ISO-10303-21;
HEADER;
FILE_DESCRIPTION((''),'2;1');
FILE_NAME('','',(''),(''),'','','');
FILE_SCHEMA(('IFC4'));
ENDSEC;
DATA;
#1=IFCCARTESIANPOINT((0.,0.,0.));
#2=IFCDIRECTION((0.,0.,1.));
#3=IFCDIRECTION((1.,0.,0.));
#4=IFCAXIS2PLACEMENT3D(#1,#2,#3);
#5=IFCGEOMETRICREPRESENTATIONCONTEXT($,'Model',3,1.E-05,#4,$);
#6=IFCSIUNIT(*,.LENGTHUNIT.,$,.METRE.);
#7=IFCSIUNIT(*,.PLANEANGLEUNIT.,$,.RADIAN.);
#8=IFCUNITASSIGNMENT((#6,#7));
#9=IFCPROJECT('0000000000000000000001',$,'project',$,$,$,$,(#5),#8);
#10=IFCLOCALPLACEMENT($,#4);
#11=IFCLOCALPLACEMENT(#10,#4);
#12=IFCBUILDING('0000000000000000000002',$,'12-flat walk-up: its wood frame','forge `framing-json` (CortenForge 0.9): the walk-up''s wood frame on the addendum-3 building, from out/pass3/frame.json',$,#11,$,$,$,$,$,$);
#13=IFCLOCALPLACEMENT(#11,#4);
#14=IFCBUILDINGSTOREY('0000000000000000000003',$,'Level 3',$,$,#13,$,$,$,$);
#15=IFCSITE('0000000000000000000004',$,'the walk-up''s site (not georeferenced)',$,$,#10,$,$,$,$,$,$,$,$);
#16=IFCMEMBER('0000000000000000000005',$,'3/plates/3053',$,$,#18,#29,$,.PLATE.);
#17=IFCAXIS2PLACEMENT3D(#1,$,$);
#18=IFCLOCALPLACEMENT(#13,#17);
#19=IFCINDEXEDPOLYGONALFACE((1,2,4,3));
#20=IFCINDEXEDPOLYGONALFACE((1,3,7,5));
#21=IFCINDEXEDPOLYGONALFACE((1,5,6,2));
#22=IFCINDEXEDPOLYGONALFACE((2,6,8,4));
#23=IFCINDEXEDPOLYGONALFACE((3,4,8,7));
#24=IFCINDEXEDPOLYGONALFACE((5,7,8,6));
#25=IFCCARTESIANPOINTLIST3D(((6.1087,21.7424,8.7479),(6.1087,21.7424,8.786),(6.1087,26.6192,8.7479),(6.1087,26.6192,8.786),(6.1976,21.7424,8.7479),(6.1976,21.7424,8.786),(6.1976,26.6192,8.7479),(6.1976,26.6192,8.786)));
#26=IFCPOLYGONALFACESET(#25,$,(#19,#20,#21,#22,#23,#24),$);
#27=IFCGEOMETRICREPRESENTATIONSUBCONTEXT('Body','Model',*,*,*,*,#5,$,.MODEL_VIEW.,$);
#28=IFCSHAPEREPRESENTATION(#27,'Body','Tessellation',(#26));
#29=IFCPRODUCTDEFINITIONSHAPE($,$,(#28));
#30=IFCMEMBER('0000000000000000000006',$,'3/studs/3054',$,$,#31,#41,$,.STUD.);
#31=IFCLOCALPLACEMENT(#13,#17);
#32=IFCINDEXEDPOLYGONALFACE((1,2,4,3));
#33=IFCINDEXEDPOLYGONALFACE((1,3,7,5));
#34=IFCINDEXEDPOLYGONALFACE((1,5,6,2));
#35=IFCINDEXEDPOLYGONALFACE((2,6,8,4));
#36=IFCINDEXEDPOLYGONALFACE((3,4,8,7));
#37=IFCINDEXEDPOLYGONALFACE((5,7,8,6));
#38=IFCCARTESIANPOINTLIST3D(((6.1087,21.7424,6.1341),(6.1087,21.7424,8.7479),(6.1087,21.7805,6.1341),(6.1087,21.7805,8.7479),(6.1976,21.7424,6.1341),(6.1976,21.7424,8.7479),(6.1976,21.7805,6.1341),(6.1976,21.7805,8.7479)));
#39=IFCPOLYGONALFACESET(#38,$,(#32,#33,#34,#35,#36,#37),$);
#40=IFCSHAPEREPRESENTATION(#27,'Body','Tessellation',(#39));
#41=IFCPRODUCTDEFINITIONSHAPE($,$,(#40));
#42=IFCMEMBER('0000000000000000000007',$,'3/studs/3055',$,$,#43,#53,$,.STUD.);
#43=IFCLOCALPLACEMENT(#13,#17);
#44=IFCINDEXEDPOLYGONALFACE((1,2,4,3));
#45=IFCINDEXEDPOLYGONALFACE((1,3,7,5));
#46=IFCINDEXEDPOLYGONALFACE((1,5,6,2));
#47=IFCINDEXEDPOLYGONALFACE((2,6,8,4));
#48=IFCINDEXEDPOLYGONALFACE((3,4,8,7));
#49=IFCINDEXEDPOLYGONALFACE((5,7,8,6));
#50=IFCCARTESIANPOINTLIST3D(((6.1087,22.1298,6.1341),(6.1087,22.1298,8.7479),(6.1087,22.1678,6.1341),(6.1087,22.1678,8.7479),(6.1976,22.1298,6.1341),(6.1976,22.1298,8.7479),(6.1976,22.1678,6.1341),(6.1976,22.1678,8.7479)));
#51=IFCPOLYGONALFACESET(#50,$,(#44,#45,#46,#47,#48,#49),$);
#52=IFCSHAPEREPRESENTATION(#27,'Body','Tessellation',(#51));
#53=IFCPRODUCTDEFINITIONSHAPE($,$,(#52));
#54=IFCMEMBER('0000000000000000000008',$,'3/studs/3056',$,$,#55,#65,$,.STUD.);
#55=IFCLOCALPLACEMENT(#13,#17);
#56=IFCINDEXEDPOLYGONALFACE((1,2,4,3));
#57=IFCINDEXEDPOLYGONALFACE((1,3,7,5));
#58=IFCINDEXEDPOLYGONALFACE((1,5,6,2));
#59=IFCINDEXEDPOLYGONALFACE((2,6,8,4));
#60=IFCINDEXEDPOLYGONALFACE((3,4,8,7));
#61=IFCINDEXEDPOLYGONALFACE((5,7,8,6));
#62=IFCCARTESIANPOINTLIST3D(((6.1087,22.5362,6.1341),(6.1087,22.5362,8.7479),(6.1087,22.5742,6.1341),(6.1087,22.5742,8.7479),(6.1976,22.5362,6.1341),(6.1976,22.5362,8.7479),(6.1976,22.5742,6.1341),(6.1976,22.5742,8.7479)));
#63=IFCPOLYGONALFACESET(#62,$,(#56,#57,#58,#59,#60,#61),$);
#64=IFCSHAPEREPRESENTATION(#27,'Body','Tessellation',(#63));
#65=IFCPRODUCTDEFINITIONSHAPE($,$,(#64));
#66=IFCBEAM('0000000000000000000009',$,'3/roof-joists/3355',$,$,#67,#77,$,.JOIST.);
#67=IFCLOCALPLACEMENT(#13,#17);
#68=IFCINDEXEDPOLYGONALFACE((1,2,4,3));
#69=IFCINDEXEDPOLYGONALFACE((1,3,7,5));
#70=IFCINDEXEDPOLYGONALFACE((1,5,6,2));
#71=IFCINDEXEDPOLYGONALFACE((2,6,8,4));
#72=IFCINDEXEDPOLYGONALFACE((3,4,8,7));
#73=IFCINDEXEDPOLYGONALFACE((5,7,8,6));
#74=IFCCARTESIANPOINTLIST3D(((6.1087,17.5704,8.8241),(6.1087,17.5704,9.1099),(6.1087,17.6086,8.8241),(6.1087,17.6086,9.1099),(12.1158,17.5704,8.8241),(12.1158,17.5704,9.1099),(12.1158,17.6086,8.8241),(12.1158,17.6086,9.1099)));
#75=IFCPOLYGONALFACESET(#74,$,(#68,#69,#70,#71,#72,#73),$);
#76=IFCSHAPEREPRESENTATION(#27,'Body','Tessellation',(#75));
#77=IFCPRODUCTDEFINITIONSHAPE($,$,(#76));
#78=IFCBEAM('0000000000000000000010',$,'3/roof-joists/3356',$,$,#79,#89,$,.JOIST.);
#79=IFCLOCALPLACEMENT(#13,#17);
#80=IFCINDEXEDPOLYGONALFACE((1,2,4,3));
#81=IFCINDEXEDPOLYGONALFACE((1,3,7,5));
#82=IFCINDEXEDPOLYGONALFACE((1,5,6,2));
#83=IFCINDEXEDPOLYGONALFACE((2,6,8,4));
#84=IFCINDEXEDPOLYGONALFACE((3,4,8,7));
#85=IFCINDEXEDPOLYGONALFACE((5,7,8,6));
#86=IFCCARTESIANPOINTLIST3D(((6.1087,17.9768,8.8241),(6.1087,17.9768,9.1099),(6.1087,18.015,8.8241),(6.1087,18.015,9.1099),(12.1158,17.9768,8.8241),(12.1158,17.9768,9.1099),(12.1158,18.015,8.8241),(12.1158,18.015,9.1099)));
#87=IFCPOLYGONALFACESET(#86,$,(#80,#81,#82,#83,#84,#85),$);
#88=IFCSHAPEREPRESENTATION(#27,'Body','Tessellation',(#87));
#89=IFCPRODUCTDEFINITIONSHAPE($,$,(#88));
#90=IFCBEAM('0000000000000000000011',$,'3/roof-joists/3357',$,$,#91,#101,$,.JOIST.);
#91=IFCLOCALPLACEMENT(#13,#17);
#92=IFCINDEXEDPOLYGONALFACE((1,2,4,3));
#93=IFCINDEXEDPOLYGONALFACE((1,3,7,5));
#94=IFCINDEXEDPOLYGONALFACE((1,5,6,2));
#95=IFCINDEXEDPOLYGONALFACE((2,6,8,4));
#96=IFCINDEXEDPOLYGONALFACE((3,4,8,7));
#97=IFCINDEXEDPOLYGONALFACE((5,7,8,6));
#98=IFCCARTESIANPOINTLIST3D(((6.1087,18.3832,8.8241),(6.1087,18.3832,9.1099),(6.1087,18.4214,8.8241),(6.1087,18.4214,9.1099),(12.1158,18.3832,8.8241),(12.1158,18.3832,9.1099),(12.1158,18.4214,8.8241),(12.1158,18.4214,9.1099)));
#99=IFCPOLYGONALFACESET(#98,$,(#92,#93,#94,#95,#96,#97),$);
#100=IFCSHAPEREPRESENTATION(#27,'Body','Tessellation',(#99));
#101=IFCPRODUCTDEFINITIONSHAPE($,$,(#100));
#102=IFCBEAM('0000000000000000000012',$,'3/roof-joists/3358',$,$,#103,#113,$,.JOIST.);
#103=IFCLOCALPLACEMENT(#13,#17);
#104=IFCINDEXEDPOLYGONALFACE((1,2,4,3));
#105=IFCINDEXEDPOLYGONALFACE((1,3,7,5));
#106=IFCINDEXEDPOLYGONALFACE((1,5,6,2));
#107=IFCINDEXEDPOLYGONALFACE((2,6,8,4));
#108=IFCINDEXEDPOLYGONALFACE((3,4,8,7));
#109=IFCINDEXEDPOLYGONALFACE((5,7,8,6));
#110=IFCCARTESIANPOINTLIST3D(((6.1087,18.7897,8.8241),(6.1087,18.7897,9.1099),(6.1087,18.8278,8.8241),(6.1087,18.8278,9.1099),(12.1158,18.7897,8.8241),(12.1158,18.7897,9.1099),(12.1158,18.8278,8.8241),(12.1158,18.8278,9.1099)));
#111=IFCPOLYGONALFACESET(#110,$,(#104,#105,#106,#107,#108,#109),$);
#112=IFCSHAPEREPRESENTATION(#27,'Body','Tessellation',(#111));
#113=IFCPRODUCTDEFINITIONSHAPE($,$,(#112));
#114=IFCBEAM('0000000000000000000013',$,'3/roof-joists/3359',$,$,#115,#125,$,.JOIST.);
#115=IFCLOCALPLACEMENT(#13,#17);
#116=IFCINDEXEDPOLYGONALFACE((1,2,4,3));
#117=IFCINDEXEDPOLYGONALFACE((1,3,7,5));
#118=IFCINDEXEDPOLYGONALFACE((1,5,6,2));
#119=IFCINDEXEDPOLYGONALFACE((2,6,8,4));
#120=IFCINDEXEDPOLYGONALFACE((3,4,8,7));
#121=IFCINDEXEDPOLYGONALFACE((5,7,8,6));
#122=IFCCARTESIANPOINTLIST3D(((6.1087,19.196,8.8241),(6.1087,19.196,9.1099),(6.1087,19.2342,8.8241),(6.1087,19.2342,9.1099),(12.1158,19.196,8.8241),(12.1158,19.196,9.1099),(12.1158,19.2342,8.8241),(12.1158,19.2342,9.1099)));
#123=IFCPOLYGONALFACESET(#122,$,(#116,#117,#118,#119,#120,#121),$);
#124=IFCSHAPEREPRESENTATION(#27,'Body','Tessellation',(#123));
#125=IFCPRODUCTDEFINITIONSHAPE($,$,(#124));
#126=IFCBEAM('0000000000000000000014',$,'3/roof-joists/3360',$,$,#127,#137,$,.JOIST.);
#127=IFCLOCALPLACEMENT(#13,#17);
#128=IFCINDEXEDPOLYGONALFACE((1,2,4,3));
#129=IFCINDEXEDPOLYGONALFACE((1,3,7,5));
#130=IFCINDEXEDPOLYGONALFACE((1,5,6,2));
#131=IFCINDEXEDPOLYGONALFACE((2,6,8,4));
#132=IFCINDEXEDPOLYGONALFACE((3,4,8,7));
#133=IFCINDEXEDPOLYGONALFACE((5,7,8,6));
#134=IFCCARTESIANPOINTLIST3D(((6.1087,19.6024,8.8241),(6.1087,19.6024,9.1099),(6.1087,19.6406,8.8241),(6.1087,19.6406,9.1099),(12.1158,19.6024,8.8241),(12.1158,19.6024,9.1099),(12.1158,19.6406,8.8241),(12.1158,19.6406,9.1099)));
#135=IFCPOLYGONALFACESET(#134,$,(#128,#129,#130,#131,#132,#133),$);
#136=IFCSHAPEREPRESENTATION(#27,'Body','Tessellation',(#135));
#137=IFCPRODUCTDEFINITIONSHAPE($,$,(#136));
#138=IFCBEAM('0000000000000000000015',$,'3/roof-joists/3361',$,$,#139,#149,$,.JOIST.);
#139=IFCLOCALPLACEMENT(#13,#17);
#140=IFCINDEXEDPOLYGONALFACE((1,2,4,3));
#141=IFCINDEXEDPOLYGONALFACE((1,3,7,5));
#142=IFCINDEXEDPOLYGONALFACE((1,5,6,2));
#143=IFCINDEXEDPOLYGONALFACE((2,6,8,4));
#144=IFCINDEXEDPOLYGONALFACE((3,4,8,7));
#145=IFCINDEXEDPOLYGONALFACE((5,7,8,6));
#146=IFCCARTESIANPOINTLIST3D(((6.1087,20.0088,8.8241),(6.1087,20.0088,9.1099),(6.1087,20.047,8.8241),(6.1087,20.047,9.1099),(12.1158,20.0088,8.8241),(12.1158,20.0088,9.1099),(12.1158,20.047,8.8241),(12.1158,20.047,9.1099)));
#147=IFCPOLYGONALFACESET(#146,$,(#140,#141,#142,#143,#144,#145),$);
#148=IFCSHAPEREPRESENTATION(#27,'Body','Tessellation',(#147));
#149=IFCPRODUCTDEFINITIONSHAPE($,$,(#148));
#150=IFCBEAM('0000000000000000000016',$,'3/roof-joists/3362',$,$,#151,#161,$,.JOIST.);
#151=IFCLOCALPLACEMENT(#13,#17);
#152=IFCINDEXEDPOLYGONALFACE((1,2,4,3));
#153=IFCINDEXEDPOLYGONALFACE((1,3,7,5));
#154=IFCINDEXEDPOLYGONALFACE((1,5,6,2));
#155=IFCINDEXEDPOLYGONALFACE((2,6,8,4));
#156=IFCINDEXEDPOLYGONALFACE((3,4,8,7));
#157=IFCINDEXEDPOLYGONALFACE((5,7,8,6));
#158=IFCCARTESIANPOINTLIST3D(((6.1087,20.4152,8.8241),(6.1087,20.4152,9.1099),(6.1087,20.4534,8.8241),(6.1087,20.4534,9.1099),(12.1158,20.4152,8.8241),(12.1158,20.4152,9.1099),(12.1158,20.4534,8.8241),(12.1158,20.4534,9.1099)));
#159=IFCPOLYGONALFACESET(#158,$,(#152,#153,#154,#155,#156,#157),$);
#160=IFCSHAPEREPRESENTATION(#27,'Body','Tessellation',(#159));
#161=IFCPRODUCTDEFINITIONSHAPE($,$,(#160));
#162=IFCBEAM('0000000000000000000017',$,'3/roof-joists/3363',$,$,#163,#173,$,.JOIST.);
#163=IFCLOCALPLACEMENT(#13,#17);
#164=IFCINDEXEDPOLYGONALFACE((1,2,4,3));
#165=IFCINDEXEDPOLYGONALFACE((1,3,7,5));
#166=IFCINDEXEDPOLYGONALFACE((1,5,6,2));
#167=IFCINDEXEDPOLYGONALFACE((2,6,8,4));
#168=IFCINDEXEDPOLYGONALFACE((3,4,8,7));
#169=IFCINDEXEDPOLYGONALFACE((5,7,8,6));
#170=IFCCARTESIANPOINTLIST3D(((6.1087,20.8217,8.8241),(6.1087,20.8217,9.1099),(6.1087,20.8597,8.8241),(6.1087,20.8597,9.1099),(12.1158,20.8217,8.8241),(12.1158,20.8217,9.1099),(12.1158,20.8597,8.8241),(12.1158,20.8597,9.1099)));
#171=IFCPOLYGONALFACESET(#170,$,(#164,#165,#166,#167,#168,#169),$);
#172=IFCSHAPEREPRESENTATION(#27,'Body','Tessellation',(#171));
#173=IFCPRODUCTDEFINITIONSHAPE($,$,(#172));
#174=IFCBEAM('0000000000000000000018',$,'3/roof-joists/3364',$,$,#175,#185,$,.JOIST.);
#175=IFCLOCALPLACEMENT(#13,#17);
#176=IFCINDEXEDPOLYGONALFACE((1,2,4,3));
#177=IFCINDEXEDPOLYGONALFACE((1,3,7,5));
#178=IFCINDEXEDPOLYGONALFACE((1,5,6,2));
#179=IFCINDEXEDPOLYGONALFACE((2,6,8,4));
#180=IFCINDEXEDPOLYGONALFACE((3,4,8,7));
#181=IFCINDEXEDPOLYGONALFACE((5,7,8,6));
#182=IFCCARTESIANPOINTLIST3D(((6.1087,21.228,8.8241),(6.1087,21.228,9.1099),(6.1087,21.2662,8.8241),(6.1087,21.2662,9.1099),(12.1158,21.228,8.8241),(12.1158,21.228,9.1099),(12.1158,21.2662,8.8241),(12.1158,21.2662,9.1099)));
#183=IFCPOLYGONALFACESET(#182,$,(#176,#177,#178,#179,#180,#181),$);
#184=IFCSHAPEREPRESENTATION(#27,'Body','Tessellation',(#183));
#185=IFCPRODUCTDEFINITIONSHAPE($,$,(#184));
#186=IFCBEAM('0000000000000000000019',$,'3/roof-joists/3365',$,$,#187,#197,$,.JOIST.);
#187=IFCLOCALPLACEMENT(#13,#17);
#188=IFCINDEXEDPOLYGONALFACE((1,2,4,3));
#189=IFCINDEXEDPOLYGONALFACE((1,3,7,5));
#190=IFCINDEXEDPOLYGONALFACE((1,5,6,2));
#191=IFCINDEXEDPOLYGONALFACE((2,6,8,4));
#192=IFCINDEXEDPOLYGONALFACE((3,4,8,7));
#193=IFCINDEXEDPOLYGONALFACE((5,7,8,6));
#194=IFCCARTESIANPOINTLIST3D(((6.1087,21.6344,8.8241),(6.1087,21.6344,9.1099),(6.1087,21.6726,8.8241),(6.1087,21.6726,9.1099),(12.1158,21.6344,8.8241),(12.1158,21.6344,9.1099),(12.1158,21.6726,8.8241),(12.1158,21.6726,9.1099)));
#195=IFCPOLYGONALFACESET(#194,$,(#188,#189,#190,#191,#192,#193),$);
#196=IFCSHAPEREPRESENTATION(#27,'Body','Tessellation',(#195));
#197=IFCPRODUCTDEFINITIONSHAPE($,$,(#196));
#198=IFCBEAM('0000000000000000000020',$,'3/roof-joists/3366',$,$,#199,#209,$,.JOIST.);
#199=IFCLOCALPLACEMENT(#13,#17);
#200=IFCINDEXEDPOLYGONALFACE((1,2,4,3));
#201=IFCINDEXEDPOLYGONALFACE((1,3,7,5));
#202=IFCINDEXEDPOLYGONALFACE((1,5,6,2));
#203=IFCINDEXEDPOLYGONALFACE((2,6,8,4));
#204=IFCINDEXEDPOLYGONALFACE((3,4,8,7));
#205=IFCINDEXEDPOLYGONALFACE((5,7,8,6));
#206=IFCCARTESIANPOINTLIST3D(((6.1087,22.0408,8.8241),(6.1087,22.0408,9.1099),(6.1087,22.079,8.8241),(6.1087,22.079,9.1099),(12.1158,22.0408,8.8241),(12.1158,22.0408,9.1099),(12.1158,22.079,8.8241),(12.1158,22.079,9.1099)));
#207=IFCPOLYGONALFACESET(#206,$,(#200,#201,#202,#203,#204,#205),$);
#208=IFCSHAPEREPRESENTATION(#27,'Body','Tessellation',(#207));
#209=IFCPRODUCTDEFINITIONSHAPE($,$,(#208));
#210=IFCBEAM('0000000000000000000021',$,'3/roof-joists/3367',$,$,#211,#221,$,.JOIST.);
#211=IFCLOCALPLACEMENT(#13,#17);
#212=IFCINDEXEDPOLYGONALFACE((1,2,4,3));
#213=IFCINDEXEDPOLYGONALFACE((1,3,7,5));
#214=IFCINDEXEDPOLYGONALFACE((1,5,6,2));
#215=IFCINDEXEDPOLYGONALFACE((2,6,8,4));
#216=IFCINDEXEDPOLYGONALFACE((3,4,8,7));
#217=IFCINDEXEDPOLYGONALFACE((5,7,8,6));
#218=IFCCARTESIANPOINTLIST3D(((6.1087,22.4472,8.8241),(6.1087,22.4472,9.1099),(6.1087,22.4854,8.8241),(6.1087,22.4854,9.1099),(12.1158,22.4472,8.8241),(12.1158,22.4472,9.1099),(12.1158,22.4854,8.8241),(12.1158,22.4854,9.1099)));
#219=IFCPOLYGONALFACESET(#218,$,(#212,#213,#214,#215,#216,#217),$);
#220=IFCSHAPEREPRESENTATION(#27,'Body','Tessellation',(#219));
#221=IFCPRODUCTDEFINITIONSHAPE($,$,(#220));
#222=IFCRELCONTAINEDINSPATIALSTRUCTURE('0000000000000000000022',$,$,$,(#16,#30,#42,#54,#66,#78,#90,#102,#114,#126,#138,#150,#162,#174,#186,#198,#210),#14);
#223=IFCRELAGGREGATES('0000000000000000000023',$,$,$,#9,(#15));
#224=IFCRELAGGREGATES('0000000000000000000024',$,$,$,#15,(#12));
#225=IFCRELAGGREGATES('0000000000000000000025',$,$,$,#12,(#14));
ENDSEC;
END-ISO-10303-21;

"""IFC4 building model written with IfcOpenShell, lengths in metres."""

from ifc_helpers import new_model, si_unit, frame, frame_2d, origin, origin_with_axes, place, context, subcontext, project, spatial, rectangle, extrude, element, save


model = new_model("IFC4")

# Units and contexts
model_context = context("Model", 3, precision=1e-05, world=origin_with_axes())
body_context = subcontext(model_context, "Body", "Model", "MODEL_VIEW")
ifc_project = project(units=[si_unit("LENGTHUNIT", "METRE"), si_unit("PLANEANGLEUNIT", "RADIAN")], contexts=[model_context])

# Site, building, storey
site_placement = place(None, origin_with_axes())
site = spatial("IfcSite", under=ifc_project, at=site_placement, Name="the walk-up's site (not georeferenced)")
building_placement = place(site_placement, origin_with_axes())
building = spatial("IfcBuilding", under=site, at=building_placement, Name="12-flat walk-up: its wood frame", Description="forge `framing-json` (CortenForge 0.9): the walk-up's wood frame on the addendum-3 building, from out/pass3/frame.json")
storey_placement = place(building_placement, origin_with_axes())
storey = spatial("IfcBuildingStorey", under=building, at=storey_placement, Name="Level 3")

# Members
for number, where, z_axis, x_axis, name in (
    (1, (6.1087, 21.7424, 8.7479), (0.0, 0.0, 1.0), (1.0, 0.0, 0.0), "3/plates/3053"),
):
    element("IfcMember", number, at=place(storey_placement, frame(where, z_axis=z_axis, x_axis=x_axis)), inside=storey, Name=name, PredefinedType="PLATE", context=body_context, shape_type="SweptSolid", body=[
        extrude(rectangle(XDim=0.0889, YDim=4.8768, at=frame_2d((0.0445, 2.4384))), origin(), (0.0, 0.0, 1.0), 0.0381),
    ])
for number, where, z_axis, x_axis, name in (
    (2, (6.1087, 21.7424, 6.1341), (0.0, 0.0, 1.0), (1.0, 0.0, 0.0), "3/studs/3054"),
    (3, (6.1087, 22.1298, 6.1341), (0.0, 0.0, 1.0), (1.0, 0.0, 0.0), "3/studs/3055"),
    (4, (6.1087, 22.5361, 6.1341), (0.0, 0.0, 1.0), (1.0, 0.0, 0.0), "3/studs/3056"),
):
    element("IfcMember", number, at=place(storey_placement, frame(where, z_axis=z_axis, x_axis=x_axis)), inside=storey, Name=name, PredefinedType="STUD", context=body_context, shape_type="SweptSolid", body=[
        extrude(rectangle(XDim=0.0889, YDim=0.0381, at=frame_2d((0.0445, 0.0191))), origin(), (0.0, 0.0, 1.0), 2.6138),
    ])

# Beams
for number, where, z_axis, x_axis, name in (
    (5, (6.1087, 17.5705, 8.8241), (0.0, 0.0, 1.0), (1.0, 0.0, 0.0), "3/roof-joists/3355"),
    (6, (6.1087, 17.9768, 8.8241), (0.0, 0.0, 1.0), (1.0, 0.0, 0.0), "3/roof-joists/3356"),
    (7, (6.1087, 18.3833, 8.8241), (0.0, 0.0, 1.0), (1.0, 0.0, 0.0), "3/roof-joists/3357"),
    (8, (6.1087, 18.7897, 8.8241), (0.0, 0.0, 1.0), (1.0, 0.0, 0.0), "3/roof-joists/3358"),
    (9, (6.1087, 19.196, 8.8241), (0.0, 0.0, 1.0), (1.0, 0.0, 0.0), "3/roof-joists/3359"),
    (10, (6.1087, 19.6025, 8.8241), (0.0, 0.0, 1.0), (1.0, 0.0, 0.0), "3/roof-joists/3360"),
    (11, (6.1087, 20.0088, 8.8241), (0.0, 0.0, 1.0), (1.0, 0.0, 0.0), "3/roof-joists/3361"),
    (12, (6.1087, 20.4153, 8.8241), (0.0, 0.0, 1.0), (1.0, 0.0, 0.0), "3/roof-joists/3362"),
):
    element("IfcBeam", number, at=place(storey_placement, frame(where, z_axis=z_axis, x_axis=x_axis)), inside=storey, Name=name, PredefinedType="JOIST", context=body_context, shape_type="SweptSolid", body=[
        extrude(rectangle(XDim=6.0071, YDim=0.0381, at=frame_2d((3.0036, 0.0191))), origin(), (0.0, 0.0, 1.0), 0.2858),
    ])
beam_placement = place(storey_placement, frame((6.1087, 20.8217, 8.8241), z_axis=(0.0, 0.0, 1.0), x_axis=(1.0, 0.0, 0.0)))
element("IfcBeam", 13, at=beam_placement, inside=storey, Name="3/roof-joists/3363", PredefinedType="JOIST", context=body_context, shape_type="SweptSolid", body=[
    extrude(rectangle(XDim=6.0071, YDim=0.0381, at=frame_2d((3.0036, 0.019))), origin(), (0.0, 0.0, 1.0), 0.2858),
])
for number, where, z_axis, x_axis, name in (
    (14, (6.1087, 21.228, 8.8241), (0.0, 0.0, 1.0), (1.0, 0.0, 0.0), "3/roof-joists/3364"),
    (15, (6.1087, 21.6345, 8.8241), (0.0, 0.0, 1.0), (1.0, 0.0, 0.0), "3/roof-joists/3365"),
    (16, (6.1087, 22.0408, 8.8241), (0.0, 0.0, 1.0), (1.0, 0.0, 0.0), "3/roof-joists/3366"),
    (17, (6.1087, 22.4473, 8.8241), (0.0, 0.0, 1.0), (1.0, 0.0, 0.0), "3/roof-joists/3367"),
):
    element("IfcBeam", number, at=place(storey_placement, frame(where, z_axis=z_axis, x_axis=x_axis)), inside=storey, Name=name, PredefinedType="JOIST", context=body_context, shape_type="SweptSolid", body=[
        extrude(rectangle(XDim=6.0071, YDim=0.0381, at=frame_2d((3.0036, 0.0191))), origin(), (0.0, 0.0, 1.0), 0.2858),
    ])

save(model, "model.ifc")
